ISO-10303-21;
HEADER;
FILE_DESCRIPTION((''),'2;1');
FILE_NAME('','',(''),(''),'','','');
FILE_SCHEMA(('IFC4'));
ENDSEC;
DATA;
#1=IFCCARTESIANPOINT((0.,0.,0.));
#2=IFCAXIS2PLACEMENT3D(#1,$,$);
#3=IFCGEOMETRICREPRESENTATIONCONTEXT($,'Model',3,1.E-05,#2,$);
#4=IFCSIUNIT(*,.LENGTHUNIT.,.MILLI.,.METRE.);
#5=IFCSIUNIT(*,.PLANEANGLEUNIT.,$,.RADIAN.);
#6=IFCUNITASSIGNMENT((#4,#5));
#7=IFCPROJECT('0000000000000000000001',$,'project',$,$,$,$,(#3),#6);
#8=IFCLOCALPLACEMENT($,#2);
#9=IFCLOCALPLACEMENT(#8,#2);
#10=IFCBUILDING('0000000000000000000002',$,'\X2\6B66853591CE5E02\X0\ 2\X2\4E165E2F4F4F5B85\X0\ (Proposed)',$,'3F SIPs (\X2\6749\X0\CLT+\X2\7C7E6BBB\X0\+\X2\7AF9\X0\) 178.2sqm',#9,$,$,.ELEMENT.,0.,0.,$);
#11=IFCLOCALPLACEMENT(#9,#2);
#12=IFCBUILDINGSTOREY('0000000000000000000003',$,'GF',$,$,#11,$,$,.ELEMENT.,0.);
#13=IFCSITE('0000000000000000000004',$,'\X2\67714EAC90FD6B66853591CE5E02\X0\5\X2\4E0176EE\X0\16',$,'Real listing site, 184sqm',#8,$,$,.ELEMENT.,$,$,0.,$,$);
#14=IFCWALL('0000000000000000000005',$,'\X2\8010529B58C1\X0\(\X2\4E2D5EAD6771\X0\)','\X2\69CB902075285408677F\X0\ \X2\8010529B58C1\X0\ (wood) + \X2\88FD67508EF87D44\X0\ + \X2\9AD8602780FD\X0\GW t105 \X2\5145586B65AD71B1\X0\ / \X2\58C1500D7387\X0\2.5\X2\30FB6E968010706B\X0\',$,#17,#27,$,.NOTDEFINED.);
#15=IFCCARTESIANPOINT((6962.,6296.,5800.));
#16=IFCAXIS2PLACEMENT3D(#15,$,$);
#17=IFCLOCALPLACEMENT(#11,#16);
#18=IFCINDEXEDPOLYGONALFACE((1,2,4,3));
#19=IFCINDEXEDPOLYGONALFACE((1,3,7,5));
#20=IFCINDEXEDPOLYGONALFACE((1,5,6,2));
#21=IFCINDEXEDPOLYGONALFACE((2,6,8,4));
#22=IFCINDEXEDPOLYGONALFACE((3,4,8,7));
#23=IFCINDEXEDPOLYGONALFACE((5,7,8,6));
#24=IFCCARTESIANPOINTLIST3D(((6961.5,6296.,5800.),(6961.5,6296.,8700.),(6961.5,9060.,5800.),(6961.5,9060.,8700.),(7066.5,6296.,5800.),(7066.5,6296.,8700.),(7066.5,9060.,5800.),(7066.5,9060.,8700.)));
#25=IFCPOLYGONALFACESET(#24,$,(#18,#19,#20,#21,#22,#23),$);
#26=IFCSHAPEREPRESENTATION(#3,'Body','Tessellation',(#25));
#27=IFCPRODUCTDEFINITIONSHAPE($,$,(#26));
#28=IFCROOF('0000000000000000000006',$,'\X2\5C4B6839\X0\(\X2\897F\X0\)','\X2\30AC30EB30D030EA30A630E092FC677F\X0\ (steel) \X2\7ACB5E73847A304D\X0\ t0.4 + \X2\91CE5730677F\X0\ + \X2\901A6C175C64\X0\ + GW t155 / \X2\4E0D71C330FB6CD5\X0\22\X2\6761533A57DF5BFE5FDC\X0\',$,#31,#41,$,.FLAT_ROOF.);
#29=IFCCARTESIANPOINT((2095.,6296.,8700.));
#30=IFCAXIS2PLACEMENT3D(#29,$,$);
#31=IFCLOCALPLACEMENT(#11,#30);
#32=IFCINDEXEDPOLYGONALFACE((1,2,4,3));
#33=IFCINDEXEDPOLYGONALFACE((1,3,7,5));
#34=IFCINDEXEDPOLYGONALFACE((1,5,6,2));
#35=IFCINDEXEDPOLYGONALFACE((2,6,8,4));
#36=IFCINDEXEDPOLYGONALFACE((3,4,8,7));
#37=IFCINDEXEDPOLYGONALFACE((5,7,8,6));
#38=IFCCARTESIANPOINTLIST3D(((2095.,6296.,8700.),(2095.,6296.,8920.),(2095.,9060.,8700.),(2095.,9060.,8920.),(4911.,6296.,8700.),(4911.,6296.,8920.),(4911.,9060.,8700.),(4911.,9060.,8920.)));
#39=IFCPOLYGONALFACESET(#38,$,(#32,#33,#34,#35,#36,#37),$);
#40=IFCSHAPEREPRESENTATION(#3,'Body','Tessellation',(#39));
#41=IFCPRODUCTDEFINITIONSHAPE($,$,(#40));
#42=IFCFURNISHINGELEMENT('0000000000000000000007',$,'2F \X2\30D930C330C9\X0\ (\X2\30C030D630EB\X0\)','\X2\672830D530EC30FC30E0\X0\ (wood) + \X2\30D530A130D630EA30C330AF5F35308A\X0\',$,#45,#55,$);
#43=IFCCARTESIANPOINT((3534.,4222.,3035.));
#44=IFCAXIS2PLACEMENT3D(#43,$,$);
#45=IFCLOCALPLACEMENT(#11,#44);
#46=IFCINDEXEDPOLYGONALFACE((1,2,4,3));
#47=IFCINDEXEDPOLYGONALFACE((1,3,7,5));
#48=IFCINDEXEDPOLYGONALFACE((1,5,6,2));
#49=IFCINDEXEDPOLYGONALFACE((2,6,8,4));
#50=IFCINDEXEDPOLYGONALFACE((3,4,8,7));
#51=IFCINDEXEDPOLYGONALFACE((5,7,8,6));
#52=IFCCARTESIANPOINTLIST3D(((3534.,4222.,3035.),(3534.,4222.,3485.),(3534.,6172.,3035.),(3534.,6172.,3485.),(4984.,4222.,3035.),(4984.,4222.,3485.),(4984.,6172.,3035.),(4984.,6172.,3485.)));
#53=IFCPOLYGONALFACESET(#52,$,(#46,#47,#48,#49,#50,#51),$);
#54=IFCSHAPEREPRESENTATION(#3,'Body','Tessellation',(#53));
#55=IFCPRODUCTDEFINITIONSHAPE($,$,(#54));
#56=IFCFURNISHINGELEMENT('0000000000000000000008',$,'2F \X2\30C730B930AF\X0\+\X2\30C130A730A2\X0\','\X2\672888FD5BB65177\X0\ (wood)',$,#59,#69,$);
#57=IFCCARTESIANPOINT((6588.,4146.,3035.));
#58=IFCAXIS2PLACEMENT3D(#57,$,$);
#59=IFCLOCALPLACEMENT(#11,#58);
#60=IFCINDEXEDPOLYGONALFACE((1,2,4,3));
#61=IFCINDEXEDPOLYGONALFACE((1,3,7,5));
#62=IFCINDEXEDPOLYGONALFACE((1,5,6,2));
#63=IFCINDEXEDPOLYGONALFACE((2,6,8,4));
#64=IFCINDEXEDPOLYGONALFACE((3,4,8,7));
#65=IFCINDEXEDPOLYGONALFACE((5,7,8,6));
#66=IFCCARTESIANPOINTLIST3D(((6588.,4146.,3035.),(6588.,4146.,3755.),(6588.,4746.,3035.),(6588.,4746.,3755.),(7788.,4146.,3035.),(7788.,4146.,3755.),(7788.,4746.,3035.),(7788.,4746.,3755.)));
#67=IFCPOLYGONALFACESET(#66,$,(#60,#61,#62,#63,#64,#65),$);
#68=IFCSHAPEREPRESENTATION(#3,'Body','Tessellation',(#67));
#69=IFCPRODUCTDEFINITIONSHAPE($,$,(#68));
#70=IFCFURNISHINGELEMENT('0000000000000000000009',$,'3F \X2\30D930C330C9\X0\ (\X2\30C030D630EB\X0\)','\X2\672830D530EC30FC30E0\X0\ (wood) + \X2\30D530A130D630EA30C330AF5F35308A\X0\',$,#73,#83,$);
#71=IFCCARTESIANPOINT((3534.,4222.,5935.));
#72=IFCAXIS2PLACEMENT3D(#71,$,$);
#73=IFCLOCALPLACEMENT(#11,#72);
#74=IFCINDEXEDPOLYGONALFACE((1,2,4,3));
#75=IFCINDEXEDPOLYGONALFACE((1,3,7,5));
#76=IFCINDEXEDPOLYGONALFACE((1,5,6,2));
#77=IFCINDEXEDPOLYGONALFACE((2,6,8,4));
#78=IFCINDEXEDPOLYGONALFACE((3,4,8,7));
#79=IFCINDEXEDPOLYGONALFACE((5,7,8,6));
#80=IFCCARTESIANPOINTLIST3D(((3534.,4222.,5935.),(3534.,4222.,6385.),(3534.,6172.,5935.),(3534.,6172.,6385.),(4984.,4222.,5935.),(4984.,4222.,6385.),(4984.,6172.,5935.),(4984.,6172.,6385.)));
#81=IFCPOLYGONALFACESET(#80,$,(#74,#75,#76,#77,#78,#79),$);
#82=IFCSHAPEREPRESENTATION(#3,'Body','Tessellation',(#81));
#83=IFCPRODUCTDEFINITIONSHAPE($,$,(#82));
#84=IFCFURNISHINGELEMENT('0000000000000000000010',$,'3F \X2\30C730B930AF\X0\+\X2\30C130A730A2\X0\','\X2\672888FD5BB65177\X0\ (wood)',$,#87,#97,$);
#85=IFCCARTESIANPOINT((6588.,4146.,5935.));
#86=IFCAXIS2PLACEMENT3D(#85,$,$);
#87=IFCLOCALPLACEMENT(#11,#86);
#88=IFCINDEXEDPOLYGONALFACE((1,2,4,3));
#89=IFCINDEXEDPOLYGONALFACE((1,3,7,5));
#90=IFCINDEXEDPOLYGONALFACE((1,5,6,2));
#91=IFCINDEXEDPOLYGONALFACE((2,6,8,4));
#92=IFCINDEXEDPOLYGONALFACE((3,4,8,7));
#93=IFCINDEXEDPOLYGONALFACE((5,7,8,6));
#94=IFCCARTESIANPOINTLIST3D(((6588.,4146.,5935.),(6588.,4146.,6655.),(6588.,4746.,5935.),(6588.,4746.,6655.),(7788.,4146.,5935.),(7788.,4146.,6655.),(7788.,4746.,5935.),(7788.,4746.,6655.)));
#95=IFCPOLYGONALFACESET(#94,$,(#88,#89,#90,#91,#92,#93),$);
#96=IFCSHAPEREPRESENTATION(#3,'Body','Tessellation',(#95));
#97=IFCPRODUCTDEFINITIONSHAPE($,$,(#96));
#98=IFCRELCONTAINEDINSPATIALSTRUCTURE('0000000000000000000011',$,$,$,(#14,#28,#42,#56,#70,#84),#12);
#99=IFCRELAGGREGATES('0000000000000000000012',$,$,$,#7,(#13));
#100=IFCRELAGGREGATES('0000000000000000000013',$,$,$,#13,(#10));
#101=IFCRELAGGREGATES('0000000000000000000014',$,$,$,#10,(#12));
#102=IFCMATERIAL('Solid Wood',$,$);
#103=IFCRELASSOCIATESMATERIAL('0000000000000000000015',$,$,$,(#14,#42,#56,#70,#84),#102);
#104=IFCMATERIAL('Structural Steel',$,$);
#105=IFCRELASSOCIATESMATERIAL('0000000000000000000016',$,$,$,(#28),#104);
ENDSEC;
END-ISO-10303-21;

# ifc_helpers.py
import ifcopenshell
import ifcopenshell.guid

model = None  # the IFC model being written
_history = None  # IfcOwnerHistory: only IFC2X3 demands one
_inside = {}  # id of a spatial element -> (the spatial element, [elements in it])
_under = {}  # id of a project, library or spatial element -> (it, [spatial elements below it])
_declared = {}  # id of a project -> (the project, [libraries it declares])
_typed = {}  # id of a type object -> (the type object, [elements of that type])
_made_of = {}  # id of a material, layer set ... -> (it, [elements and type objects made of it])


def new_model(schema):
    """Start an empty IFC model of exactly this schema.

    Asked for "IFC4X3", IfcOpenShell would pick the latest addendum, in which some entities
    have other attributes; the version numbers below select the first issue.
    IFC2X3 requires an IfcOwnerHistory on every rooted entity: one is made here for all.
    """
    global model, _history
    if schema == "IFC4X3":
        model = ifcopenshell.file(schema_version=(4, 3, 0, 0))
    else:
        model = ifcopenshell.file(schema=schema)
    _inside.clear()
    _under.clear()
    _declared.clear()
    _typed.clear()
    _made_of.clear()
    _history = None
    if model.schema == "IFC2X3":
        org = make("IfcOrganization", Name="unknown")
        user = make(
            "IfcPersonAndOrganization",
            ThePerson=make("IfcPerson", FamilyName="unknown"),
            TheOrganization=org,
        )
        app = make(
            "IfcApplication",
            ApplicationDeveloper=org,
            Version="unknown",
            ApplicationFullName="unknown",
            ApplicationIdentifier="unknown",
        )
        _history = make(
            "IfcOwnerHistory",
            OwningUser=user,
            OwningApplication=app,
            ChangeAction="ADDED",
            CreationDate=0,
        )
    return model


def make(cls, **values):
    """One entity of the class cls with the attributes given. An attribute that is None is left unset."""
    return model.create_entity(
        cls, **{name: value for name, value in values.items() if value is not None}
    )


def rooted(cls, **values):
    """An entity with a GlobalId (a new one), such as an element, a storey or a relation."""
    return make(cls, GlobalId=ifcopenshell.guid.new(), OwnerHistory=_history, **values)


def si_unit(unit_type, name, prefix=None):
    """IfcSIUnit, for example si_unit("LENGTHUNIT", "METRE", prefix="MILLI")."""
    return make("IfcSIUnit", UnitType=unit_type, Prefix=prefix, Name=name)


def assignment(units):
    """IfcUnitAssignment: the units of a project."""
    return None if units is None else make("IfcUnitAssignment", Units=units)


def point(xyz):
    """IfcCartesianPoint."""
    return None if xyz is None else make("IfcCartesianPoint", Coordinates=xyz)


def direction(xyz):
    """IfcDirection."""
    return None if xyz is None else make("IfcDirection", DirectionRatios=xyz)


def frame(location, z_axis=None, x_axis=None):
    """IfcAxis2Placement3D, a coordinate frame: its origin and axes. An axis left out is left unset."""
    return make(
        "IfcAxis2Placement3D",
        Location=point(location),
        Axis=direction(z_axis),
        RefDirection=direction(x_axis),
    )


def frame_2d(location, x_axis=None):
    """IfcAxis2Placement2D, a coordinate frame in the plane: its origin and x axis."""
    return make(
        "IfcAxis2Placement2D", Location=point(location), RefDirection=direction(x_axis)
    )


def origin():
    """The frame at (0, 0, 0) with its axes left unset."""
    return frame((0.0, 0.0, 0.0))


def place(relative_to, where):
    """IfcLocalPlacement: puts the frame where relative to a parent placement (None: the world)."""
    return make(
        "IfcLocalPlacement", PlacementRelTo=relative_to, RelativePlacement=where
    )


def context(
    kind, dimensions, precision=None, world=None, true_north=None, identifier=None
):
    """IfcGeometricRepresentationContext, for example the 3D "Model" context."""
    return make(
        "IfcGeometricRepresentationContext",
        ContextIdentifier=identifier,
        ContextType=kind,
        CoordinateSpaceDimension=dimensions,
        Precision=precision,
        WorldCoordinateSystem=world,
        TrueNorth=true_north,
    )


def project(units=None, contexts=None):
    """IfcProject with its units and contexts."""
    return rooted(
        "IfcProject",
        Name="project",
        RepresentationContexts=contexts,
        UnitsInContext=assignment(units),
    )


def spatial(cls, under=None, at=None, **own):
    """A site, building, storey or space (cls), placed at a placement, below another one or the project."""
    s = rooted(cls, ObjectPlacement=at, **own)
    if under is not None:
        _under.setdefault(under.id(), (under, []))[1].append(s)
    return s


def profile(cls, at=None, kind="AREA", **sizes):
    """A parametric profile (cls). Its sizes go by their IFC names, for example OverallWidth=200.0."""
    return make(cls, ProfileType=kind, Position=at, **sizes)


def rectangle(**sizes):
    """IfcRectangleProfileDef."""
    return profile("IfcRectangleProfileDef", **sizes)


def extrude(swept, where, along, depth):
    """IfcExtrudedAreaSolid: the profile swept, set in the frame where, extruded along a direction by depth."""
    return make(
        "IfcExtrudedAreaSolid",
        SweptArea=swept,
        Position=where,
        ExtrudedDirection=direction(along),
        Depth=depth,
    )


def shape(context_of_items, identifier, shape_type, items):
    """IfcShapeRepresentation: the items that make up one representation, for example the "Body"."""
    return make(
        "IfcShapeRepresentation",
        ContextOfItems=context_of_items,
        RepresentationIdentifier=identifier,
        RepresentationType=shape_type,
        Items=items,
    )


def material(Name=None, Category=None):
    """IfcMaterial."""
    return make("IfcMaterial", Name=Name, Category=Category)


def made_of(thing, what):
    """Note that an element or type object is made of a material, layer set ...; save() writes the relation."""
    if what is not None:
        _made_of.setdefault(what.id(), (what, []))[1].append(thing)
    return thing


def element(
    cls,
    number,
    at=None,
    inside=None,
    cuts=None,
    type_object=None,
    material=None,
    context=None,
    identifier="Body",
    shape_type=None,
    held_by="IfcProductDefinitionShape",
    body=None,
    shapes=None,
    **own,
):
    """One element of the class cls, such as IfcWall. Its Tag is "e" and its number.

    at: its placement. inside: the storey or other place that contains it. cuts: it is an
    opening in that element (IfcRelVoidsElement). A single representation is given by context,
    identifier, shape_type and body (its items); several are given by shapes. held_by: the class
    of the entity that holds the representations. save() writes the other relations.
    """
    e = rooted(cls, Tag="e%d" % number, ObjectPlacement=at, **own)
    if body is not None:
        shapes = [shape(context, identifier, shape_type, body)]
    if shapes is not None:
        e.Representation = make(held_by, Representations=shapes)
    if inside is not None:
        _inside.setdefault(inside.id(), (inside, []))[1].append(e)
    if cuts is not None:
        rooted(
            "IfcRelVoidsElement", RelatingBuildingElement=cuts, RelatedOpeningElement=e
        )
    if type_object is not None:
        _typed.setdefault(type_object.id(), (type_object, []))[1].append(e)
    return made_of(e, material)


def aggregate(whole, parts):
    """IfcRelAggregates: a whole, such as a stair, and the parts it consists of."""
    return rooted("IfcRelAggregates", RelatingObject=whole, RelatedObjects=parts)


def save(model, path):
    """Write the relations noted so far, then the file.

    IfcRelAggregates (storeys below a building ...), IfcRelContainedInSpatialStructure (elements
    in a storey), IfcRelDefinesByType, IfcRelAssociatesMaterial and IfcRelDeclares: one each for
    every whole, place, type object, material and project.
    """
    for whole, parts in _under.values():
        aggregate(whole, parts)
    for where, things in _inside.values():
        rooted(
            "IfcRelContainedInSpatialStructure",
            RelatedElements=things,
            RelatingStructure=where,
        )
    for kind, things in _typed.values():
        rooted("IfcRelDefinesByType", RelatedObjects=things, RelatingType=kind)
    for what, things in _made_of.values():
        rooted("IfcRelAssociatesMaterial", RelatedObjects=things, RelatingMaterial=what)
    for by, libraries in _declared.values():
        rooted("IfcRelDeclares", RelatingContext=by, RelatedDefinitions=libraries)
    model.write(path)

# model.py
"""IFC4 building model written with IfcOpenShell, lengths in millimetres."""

from ifc_helpers import new_model, si_unit, frame, frame_2d, origin, place, context, project, spatial, rectangle, extrude, material, element, save


model = new_model("IFC4")

# Units and contexts
model_context = context("Model", 3, precision=1e-05, world=origin())
ifc_project = project(units=[si_unit("LENGTHUNIT", "METRE", prefix="MILLI"), si_unit("PLANEANGLEUNIT", "RADIAN")], contexts=[model_context])

# Site, building, storey
site_placement = place(None, origin())
site = spatial("IfcSite", under=ifc_project, at=site_placement, Name="東京都武蔵野市5丁目16", ObjectType="Real listing site, 184sqm", CompositionType="ELEMENT", RefElevation=0.0)
building_placement = place(site_placement, origin())
building = spatial("IfcBuilding", under=site, at=building_placement, Name="武蔵野市 2世帯住宅 (Proposed)", ObjectType="3F SIPs (杉CLT+籾殻+竹) 178.2sqm", CompositionType="ELEMENT", ElevationOfRefHeight=0.0, ElevationOfTerrain=0.0)
storey_placement = place(building_placement, origin())
storey = spatial("IfcBuildingStorey", under=building, at=storey_placement, Name="GF", CompositionType="ELEMENT", Elevation=0.0)

# Shared definitions
ifc_material_1 = material(Name="Solid Wood")

# Wall
wall_1_placement = place(storey_placement, frame((6962.0, 6296.0, 5800.0)))
element("IfcWall", 1, at=wall_1_placement, inside=storey, material=ifc_material_1, Name="耐力壁(中庭東)", Description="構造用合板 耐力壁 (wood) + 製材軸組 + 高性能GW t105 充填断熱 / 壁倍率2.5・準耐火", PredefinedType="NOTDEFINED", context=model_context, shape_type="SweptSolid", body=[
    extrude(rectangle(XDim=105.0, YDim=2764.0, at=frame_2d((52.0, 1382.0))), frame((6962.0, 6296.0, 5800.0)), (0.0, 0.0, 1.0), 2900.0),
])

# Roof
ifc_material_2 = material(Name="Structural Steel")
roof_1_placement = place(storey_placement, frame((2095.0, 6296.0, 8700.0)))
element("IfcRoof", 2, at=roof_1_placement, inside=storey, material=ifc_material_2, Name="屋根(西)", Description="ガルバリウム鋼板 (steel) 立平葺き t0.4 + 野地板 + 通気層 + GW t155 / 不燃・法22条区域対応", PredefinedType="FLAT_ROOF", context=model_context, shape_type="SweptSolid", body=[
    extrude(rectangle(XDim=2816.0, YDim=2764.0, at=frame_2d((1408.0, 1382.0))), frame((2095.0, 6296.0, 8700.0)), (0.0, 0.0, 1.0), 220.0),
])

# Furnishing elements
furnishing_1_placement = place(storey_placement, frame((3534.0, 4222.0, 3035.0)))
element("IfcFurnishingElement", 3, at=furnishing_1_placement, inside=storey, material=ifc_material_1, Name="2F ベッド (ダブル)", Description="木フレーム (wood) + ファブリック張り", context=model_context, shape_type="SweptSolid", body=[
    extrude(rectangle(XDim=1450.0, YDim=1950.0, at=frame_2d((725.0, 975.0))), frame((3534.0, 4222.0, 3035.0)), (0.0, 0.0, 1.0), 450.0),
])
furnishing_2_placement = place(storey_placement, frame((6588.0, 4146.0, 3035.0)))
element("IfcFurnishingElement", 4, at=furnishing_2_placement, inside=storey, material=ifc_material_1, Name="2F デスク+チェア", Description="木製家具 (wood)", context=model_context, shape_type="SweptSolid", body=[
    extrude(rectangle(XDim=1200.0, YDim=600.0, at=frame_2d((600.0, 300.0))), frame((6588.0, 4146.0, 3035.0)), (0.0, 0.0, 1.0), 720.0),
])
furnishing_3_placement = place(storey_placement, frame((3534.0, 4222.0, 5935.0)))
element("IfcFurnishingElement", 5, at=furnishing_3_placement, inside=storey, material=ifc_material_1, Name="3F ベッド (ダブル)", Description="木フレーム (wood) + ファブリック張り", context=model_context, shape_type="SweptSolid", body=[
    extrude(rectangle(XDim=1450.0, YDim=1950.0, at=frame_2d((725.0, 975.0))), frame((3534.0, 4222.0, 5935.0)), (0.0, 0.0, 1.0), 450.0),
])
furnishing_4_placement = place(storey_placement, frame((6588.0, 4146.0, 5935.0)))
element("IfcFurnishingElement", 6, at=furnishing_4_placement, inside=storey, material=ifc_material_1, Name="3F デスク+チェア", Description="木製家具 (wood)", context=model_context, shape_type="SweptSolid", body=[
    extrude(rectangle(XDim=1200.0, YDim=600.0, at=frame_2d((600.0, 300.0))), frame((6588.0, 4146.0, 5935.0)), (0.0, 0.0, 1.0), 720.0),
])

save(model, "model.ifc")
